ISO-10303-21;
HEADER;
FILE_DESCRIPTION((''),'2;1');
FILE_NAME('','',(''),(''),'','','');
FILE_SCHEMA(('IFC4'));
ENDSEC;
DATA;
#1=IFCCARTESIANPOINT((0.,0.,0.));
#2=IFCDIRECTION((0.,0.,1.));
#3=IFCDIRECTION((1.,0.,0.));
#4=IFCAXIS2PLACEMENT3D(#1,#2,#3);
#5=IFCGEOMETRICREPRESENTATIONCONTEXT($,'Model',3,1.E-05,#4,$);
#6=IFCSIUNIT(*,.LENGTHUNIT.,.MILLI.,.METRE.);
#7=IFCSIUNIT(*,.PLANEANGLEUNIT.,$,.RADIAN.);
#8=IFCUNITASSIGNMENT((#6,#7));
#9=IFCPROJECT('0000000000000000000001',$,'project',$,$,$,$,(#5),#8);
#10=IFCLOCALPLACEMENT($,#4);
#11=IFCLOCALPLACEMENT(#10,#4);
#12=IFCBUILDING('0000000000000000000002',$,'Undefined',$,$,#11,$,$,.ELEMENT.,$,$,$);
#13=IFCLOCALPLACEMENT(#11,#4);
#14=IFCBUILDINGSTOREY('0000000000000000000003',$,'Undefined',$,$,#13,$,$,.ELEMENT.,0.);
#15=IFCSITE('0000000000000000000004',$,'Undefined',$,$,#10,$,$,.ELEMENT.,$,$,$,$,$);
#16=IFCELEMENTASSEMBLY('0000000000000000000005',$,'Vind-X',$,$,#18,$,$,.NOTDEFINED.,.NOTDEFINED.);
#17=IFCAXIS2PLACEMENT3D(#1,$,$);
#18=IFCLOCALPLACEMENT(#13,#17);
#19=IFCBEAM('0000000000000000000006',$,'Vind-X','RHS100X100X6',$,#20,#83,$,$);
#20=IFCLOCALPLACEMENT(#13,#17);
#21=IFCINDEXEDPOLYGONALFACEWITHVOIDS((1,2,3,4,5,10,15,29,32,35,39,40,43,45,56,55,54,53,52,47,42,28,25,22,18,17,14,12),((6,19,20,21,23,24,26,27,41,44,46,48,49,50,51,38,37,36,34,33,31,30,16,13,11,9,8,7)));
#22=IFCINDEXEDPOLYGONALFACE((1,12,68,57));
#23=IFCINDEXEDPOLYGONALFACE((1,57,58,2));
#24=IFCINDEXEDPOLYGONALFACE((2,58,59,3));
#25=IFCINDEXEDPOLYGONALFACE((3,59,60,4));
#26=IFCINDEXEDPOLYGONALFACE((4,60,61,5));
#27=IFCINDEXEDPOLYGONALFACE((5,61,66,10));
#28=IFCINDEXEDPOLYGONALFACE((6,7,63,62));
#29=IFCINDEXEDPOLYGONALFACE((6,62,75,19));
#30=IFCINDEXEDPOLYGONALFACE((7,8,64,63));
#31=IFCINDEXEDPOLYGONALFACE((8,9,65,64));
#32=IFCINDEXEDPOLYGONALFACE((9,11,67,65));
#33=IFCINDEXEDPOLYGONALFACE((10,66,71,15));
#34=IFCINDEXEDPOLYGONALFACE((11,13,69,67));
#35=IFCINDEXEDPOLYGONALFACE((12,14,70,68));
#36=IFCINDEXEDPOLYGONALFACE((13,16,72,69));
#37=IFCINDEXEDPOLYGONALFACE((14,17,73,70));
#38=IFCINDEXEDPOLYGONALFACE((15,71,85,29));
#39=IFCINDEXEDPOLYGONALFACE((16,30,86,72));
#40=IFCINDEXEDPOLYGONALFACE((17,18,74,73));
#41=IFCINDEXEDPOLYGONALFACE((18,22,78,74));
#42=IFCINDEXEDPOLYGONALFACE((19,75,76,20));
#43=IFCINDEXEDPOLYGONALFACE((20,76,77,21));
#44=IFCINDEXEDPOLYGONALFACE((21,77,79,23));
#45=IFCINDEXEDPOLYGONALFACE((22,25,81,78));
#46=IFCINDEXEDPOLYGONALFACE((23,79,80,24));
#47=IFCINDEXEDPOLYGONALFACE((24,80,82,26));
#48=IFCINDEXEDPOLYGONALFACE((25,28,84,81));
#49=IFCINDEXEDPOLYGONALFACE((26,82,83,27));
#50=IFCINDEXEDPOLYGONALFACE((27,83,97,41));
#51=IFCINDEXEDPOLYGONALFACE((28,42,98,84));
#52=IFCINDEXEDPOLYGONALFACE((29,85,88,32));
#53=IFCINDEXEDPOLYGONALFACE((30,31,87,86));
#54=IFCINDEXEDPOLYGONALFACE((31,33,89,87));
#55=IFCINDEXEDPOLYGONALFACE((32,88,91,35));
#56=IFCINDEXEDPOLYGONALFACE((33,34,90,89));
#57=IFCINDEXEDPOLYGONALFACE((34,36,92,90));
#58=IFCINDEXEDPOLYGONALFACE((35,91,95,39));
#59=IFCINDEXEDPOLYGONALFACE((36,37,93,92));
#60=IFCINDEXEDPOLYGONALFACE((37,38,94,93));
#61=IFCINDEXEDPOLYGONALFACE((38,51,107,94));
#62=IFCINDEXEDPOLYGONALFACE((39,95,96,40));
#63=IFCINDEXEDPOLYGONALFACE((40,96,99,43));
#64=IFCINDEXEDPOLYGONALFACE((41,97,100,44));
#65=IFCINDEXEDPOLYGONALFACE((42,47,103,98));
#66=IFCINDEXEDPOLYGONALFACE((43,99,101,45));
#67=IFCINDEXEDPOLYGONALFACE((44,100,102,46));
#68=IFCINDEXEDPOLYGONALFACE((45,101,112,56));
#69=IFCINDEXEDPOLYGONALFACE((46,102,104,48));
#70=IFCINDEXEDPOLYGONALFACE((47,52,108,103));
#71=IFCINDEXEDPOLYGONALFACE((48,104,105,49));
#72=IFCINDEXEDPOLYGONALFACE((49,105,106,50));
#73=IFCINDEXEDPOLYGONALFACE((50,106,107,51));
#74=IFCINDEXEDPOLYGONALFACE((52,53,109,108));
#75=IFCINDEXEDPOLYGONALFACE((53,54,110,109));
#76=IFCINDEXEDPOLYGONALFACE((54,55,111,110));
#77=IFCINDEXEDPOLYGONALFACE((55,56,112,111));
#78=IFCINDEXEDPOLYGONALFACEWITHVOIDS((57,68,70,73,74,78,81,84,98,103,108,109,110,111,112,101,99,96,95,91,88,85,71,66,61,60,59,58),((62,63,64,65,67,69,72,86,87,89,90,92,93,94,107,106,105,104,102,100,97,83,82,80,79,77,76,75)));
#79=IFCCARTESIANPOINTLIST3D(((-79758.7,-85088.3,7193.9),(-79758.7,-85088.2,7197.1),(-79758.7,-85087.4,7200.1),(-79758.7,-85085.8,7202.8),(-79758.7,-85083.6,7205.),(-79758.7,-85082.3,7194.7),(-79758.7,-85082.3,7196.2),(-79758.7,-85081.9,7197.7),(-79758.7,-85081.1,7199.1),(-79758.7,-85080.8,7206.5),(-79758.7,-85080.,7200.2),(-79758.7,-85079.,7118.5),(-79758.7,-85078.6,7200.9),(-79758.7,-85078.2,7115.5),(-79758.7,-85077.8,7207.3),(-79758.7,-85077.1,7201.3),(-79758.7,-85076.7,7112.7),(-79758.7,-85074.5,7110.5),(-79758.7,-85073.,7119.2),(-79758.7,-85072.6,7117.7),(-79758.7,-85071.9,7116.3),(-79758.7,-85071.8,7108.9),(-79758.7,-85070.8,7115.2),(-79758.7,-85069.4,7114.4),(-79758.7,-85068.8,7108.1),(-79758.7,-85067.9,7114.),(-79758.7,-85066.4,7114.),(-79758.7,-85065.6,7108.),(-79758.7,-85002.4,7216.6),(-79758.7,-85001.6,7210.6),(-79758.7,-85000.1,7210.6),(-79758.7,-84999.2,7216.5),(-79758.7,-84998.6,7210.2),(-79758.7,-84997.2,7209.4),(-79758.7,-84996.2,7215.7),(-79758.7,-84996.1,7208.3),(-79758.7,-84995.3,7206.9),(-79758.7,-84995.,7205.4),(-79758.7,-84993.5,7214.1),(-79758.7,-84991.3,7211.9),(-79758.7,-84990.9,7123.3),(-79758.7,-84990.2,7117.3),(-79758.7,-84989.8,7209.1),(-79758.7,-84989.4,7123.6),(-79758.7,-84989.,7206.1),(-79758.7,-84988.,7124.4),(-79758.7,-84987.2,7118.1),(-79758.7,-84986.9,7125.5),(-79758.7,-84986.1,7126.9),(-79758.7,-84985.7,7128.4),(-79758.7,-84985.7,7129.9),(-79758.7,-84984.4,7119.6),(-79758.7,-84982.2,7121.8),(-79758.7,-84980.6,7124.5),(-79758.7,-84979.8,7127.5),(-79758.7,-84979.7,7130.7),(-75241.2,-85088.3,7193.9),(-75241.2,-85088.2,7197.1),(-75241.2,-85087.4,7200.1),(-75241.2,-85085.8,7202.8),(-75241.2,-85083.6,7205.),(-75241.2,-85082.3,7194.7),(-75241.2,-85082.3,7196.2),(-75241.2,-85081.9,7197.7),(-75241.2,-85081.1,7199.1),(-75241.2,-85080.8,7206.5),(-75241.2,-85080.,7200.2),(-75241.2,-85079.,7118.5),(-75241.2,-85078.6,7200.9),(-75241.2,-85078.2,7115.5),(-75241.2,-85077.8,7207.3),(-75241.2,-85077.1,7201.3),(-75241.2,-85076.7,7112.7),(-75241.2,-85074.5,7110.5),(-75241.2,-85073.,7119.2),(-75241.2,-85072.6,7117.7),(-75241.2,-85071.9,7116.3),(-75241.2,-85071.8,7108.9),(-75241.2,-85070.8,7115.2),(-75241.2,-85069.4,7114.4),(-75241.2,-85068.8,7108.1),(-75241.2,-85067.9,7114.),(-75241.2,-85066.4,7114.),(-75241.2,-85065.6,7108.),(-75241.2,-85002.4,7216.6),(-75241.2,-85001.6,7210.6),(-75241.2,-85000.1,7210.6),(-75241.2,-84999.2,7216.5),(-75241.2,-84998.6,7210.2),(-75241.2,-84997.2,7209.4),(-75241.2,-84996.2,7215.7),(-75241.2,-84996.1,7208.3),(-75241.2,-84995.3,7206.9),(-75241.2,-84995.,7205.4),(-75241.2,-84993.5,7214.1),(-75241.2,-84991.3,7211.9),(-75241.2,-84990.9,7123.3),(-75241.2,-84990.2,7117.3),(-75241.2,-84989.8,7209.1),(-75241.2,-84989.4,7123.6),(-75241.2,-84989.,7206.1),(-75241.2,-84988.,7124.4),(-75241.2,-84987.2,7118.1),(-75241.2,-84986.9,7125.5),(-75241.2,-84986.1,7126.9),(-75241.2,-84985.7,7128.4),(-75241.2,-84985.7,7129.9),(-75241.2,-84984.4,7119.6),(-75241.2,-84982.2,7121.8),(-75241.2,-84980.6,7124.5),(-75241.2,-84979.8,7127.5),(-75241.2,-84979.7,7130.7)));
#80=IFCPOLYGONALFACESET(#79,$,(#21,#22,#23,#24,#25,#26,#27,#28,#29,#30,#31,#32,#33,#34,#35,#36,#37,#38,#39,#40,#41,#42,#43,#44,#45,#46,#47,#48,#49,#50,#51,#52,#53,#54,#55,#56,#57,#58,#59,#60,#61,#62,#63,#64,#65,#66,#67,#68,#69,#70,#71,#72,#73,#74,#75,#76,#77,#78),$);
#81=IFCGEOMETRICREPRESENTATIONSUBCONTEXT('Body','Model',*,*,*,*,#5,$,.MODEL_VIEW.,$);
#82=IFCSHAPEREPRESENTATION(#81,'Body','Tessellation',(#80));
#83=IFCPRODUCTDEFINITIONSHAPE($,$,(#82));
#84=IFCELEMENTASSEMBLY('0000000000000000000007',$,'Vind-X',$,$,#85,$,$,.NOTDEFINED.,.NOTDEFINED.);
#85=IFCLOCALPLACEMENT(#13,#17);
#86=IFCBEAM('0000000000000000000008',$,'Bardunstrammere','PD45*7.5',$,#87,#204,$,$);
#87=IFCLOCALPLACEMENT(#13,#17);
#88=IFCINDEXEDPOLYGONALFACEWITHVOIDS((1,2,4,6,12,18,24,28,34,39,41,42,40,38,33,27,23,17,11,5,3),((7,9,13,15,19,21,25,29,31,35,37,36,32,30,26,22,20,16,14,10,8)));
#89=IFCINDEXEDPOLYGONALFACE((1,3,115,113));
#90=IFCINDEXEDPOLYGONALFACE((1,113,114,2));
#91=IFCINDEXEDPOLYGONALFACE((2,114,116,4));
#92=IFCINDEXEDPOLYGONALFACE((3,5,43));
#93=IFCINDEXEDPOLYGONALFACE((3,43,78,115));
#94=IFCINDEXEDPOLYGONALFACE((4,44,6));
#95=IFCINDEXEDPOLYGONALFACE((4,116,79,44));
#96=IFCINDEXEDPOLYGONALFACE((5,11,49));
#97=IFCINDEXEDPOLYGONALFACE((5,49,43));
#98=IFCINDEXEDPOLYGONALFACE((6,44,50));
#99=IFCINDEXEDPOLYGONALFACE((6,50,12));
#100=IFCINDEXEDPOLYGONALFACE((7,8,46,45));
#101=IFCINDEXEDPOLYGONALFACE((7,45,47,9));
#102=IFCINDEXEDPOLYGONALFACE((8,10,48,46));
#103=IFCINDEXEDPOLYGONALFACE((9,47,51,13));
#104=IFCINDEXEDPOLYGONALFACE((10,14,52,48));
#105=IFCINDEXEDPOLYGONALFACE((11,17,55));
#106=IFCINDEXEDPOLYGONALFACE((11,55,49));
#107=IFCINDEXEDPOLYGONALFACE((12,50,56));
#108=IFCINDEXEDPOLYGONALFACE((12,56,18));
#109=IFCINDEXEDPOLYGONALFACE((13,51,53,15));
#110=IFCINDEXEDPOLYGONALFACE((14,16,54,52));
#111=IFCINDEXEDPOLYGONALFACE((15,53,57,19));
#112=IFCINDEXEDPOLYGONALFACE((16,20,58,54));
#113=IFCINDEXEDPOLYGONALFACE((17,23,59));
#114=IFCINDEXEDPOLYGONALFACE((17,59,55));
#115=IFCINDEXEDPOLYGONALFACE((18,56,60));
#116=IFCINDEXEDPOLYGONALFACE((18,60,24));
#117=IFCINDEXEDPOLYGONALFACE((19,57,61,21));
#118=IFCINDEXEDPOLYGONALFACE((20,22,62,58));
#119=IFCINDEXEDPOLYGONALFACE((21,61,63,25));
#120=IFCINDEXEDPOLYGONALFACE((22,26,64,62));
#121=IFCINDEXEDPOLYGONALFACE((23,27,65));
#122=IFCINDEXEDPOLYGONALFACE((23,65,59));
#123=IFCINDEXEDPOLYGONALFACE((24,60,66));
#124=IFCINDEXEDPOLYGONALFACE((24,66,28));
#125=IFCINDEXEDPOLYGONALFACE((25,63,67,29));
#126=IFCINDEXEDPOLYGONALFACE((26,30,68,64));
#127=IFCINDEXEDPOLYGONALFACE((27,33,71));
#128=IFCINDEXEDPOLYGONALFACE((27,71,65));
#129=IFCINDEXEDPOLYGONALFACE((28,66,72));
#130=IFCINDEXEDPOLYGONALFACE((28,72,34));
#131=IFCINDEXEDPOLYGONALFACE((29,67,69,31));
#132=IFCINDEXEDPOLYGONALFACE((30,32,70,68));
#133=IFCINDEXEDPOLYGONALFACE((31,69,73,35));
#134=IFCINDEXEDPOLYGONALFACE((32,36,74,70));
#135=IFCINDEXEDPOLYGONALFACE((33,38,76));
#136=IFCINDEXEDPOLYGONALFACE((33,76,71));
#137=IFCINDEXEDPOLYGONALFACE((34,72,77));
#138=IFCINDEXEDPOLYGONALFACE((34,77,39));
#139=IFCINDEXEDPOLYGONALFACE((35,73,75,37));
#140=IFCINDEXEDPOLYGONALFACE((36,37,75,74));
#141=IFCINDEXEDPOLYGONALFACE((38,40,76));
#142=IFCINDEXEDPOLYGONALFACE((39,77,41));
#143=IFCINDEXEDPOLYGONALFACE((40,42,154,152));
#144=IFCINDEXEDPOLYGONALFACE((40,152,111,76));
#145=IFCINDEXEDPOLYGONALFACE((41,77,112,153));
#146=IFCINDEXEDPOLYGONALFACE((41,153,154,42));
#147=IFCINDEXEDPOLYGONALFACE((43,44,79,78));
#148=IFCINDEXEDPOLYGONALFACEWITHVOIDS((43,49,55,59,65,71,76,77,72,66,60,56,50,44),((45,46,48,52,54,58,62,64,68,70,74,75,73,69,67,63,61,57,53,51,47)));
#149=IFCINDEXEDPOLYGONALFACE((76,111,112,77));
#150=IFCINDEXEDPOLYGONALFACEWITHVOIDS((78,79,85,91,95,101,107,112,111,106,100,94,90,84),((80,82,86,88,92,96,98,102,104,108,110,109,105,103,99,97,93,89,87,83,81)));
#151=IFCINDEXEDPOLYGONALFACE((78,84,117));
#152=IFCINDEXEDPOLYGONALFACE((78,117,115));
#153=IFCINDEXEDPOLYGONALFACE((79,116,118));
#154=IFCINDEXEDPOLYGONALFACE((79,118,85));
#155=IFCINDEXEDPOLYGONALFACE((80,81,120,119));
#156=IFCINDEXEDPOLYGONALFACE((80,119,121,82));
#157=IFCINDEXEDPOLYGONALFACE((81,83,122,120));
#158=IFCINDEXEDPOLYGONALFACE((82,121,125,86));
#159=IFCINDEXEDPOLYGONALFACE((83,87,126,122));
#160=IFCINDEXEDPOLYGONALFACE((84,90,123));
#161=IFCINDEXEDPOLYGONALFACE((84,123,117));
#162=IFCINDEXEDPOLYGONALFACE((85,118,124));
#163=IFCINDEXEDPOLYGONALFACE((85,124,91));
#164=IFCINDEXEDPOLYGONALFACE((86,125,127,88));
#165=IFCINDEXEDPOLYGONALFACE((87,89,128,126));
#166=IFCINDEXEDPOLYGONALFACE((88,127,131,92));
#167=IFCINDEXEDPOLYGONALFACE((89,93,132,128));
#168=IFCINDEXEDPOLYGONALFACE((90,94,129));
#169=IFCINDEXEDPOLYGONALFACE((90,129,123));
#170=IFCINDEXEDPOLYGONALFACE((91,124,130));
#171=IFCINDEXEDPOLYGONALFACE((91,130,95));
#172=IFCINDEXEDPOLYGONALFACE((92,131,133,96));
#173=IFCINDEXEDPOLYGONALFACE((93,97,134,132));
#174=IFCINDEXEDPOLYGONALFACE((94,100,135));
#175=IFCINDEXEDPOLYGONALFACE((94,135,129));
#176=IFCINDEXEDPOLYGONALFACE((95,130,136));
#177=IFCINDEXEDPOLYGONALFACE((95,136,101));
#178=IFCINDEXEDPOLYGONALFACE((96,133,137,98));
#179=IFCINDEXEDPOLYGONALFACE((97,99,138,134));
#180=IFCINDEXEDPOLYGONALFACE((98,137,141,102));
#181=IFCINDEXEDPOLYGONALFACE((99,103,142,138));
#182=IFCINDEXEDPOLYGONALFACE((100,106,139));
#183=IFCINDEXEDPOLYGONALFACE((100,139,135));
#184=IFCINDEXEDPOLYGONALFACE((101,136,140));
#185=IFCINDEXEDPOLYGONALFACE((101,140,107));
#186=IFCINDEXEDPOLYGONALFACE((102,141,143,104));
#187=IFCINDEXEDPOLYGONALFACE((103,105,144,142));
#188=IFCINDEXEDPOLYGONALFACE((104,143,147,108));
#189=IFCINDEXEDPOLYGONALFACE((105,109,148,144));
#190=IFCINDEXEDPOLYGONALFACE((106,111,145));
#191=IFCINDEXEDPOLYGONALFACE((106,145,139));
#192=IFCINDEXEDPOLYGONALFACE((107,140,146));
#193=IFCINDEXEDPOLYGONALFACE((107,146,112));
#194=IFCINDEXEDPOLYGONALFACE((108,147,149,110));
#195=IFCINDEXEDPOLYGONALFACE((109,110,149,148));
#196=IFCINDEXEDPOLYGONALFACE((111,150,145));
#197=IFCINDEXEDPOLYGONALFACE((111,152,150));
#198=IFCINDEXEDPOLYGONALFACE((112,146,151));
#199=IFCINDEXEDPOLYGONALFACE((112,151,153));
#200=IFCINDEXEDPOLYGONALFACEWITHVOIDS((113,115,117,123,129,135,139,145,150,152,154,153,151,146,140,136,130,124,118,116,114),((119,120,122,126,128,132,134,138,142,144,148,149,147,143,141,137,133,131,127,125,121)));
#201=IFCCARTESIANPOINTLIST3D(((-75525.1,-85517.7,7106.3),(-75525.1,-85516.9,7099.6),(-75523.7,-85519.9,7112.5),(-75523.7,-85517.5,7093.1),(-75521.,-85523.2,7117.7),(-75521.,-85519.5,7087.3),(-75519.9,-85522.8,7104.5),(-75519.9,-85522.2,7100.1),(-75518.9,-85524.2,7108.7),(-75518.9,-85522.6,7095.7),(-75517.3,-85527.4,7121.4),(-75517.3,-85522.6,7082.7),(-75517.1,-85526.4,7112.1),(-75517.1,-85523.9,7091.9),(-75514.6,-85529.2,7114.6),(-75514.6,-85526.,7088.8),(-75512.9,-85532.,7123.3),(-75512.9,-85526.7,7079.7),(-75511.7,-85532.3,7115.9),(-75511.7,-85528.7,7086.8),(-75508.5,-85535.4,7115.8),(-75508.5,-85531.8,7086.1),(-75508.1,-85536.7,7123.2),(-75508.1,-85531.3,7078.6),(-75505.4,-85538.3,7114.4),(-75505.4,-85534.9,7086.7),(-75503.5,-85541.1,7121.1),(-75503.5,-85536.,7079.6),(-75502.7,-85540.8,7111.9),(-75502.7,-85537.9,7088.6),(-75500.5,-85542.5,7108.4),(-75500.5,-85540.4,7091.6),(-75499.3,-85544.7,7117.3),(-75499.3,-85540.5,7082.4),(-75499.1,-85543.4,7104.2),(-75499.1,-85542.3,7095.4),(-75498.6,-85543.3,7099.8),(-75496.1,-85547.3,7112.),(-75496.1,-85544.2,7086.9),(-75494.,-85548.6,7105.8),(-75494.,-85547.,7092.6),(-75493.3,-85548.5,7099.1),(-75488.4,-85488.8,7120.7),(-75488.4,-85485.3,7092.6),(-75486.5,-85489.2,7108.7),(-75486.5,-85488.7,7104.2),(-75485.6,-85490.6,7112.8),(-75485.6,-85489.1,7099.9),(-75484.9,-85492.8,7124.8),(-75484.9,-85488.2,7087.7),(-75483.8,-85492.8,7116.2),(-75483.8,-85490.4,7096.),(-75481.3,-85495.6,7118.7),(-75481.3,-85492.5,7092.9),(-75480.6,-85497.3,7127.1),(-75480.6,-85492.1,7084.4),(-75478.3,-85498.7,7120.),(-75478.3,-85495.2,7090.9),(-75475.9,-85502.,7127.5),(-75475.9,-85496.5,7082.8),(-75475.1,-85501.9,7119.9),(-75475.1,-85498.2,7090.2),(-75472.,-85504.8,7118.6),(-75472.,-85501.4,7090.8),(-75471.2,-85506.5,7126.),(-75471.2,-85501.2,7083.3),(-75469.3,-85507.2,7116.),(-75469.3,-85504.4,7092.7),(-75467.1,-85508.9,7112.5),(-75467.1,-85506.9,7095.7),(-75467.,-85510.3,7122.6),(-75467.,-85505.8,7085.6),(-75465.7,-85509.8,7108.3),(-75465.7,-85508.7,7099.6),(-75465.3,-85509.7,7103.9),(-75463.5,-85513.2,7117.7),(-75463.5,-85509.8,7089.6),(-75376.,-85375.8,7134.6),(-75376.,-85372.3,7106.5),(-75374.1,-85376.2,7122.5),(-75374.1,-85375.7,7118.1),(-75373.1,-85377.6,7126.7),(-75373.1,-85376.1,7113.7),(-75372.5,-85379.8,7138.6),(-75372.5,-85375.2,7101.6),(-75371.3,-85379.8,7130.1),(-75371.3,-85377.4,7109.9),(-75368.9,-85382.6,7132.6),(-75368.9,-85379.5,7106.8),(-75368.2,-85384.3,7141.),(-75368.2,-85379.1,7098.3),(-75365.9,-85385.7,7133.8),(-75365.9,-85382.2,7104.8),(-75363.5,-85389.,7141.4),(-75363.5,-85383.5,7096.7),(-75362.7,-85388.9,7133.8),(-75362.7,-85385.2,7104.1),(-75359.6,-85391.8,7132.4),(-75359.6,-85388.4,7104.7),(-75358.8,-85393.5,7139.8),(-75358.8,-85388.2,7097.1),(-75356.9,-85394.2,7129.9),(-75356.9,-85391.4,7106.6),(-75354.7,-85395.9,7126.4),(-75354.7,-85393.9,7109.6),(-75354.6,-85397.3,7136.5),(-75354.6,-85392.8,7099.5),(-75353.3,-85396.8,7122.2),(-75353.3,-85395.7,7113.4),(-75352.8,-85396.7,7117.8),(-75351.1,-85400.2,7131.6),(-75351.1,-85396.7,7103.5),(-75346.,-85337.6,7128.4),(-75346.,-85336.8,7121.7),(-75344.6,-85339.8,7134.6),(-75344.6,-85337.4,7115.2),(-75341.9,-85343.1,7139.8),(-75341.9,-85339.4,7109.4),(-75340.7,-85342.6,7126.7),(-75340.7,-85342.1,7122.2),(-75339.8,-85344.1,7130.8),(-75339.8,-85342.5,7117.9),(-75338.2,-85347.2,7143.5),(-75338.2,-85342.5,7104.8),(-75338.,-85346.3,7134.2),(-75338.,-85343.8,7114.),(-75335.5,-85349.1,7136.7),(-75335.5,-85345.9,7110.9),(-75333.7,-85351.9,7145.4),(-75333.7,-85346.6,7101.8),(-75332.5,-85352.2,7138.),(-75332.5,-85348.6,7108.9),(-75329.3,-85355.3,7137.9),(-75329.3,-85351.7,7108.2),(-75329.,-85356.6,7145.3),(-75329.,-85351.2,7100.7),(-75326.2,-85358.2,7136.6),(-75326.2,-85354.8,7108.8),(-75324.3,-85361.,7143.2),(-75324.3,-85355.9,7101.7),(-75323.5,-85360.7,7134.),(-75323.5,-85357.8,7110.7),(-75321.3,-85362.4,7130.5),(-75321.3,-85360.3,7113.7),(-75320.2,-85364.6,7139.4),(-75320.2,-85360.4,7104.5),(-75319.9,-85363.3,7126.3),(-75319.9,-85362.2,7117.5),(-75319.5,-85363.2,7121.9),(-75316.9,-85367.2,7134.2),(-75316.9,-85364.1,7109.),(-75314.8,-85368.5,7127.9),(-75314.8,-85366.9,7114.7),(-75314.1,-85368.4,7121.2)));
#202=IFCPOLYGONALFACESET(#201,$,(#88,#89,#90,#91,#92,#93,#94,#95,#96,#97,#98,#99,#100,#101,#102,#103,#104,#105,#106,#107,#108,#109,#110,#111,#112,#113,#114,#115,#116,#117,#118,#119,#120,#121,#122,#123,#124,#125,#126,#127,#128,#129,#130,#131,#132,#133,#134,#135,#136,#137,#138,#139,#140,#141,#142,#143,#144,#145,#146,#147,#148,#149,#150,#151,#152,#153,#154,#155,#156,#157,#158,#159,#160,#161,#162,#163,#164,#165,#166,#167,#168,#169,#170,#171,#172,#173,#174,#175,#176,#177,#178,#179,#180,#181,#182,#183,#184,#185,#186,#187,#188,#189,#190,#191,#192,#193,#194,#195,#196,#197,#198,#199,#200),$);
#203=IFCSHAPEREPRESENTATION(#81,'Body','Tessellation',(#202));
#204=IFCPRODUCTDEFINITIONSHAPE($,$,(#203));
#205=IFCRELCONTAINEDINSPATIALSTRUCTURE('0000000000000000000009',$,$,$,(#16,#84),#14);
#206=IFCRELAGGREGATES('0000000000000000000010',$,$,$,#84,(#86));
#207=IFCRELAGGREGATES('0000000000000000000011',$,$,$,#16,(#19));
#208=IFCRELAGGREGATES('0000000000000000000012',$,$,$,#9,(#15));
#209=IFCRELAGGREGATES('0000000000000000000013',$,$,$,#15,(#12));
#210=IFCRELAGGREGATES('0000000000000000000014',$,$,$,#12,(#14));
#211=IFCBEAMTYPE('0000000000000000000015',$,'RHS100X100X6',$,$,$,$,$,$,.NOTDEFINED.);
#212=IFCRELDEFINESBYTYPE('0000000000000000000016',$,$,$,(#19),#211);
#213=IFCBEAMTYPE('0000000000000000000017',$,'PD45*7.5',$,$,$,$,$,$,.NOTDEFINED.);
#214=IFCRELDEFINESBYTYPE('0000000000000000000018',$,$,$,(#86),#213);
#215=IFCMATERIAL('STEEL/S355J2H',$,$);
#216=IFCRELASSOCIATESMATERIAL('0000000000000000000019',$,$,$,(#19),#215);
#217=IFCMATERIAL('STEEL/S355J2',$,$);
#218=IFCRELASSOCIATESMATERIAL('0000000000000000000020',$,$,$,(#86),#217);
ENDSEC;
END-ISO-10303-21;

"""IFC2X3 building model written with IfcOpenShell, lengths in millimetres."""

from ifc_helpers import new_model, si_unit, frame, origin_with_axes, origin_2d_with_axis, place, context, subcontext, project, spatial, rectangle, hollow_rectangle, hollow_circle, extrude, boolean, clip, halfspace, material, type_object, element, aggregate, save


model = new_model("IFC2X3")

# Units and contexts
model_context = context("Model", 3, precision=1e-05, world=origin_with_axes())
body_context = subcontext(model_context, "Body", "Model", "MODEL_VIEW")
ifc_project = project(units=[si_unit("LENGTHUNIT", "METRE", prefix="MILLI"), si_unit("PLANEANGLEUNIT", "RADIAN")], contexts=[model_context])

# Site, building, storey
site_placement = place(None, origin_with_axes())
site = spatial("IfcSite", under=ifc_project, at=site_placement, Name="Undefined", CompositionType="ELEMENT")
building_placement = place(site_placement, origin_with_axes())
building = spatial("IfcBuilding", under=site, at=building_placement, Name="Undefined", CompositionType="ELEMENT")
storey_placement = place(building_placement, origin_with_axes())
storey = spatial("IfcBuildingStorey", under=building, at=storey_placement, Name="Undefined", CompositionType="ELEMENT", Elevation=0.0)

# Element assemblies, beams
assembly_1_placement = place(storey_placement, origin_with_axes())
assembly_1 = element("IfcElementAssembly", 1, at=assembly_1_placement, inside=storey, Name="Vind-X", AssemblyPlace="NOTDEFINED", PredefinedType="NOTDEFINED")
ifc_material_1 = material(Name="STEEL/S355J2H")
beam_type_1 = type_object("IfcBeamType", Name="RHS100X100X6", PredefinedType="NOTDEFINED")
beam_1_placement = place(assembly_1_placement, frame((-79836.9, -85034.0, 7162.3), z_axis=(0.0, 0.992546, 0.121869), x_axis=(1.0, 0.0, 0.0)))
beam_1 = element("IfcBeam", 2, at=beam_1_placement, type_object=beam_type_1, material=ifc_material_1, Name="Vind-X", Description="RHS100X100X6", context=body_context, shape_type="Clipping", body=[
    clip(clip(extrude(hollow_rectangle(XDim=100.0, YDim=100.0, WallThickness=6.0, InnerFilletRadius=6.0, OuterFilletRadius=12.0, at=origin_2d_with_axis()), frame((4674.6, 0.0, 0.0), z_axis=(-1.0, 0.0, 0.0), x_axis=(0.0, -1.0, 0.0)), (0.0, 0.0, 1.0), 4674.6), halfspace(frame((4595.6, 22.5, 0.0), z_axis=(-1.0, 0.0, 0.0), x_axis=(0.0, 0.0, 1.0)), True)), halfspace(frame((78.1, 22.5, 0.0), z_axis=(1.0, 0.0, 0.0), x_axis=(0.0, 0.0, -1.0)), True)),
])
assembly_2_placement = place(storey_placement, origin_with_axes())
assembly_2 = element("IfcElementAssembly", 3, at=assembly_2_placement, inside=storey, Name="Vind-X", AssemblyPlace="NOTDEFINED", PredefinedType="NOTDEFINED")
ifc_material_2 = material(Name="STEEL/S355J2")
beam_type_2 = type_object("IfcBeamType", Name="PD45*7.5", PredefinedType="NOTDEFINED")
beam_2_placement = place(assembly_2_placement, frame((-75330.1, -85352.7, 7123.2), z_axis=(0.0, 0.121869, -0.992546), x_axis=(-0.702593, -0.706288, -0.086721)))
beam_2 = element("IfcBeam", 4, at=beam_2_placement, type_object=beam_type_2, material=ifc_material_2, Name="Bardunstrammere", Description="PD45*7.5", context=body_context, shape_type="CSG", body=[
    boolean("DIFFERENCE", extrude(hollow_circle(Radius=22.5, WallThickness=7.5, at=origin_2d_with_axis()), frame((255.0, 0.0, 0.0), z_axis=(-1.0, 0.0, 0.0), x_axis=(0.0, -1.0, 0.0)), (0.0, 0.0, 1.0), 255.0), extrude(rectangle(XDim=35.0, YDim=90.0, at=origin_2d_with_axis()), frame((207.5, 0.0, 0.0), z_axis=(-1.0, 0.0, 0.0), x_axis=(0.0, -1.0, 0.0)), (0.0, 0.0, 1.0), 160.0)),
])

aggregate(assembly_2, [beam_2])

aggregate(assembly_1, [beam_1])

save(model, "model.ifc")
